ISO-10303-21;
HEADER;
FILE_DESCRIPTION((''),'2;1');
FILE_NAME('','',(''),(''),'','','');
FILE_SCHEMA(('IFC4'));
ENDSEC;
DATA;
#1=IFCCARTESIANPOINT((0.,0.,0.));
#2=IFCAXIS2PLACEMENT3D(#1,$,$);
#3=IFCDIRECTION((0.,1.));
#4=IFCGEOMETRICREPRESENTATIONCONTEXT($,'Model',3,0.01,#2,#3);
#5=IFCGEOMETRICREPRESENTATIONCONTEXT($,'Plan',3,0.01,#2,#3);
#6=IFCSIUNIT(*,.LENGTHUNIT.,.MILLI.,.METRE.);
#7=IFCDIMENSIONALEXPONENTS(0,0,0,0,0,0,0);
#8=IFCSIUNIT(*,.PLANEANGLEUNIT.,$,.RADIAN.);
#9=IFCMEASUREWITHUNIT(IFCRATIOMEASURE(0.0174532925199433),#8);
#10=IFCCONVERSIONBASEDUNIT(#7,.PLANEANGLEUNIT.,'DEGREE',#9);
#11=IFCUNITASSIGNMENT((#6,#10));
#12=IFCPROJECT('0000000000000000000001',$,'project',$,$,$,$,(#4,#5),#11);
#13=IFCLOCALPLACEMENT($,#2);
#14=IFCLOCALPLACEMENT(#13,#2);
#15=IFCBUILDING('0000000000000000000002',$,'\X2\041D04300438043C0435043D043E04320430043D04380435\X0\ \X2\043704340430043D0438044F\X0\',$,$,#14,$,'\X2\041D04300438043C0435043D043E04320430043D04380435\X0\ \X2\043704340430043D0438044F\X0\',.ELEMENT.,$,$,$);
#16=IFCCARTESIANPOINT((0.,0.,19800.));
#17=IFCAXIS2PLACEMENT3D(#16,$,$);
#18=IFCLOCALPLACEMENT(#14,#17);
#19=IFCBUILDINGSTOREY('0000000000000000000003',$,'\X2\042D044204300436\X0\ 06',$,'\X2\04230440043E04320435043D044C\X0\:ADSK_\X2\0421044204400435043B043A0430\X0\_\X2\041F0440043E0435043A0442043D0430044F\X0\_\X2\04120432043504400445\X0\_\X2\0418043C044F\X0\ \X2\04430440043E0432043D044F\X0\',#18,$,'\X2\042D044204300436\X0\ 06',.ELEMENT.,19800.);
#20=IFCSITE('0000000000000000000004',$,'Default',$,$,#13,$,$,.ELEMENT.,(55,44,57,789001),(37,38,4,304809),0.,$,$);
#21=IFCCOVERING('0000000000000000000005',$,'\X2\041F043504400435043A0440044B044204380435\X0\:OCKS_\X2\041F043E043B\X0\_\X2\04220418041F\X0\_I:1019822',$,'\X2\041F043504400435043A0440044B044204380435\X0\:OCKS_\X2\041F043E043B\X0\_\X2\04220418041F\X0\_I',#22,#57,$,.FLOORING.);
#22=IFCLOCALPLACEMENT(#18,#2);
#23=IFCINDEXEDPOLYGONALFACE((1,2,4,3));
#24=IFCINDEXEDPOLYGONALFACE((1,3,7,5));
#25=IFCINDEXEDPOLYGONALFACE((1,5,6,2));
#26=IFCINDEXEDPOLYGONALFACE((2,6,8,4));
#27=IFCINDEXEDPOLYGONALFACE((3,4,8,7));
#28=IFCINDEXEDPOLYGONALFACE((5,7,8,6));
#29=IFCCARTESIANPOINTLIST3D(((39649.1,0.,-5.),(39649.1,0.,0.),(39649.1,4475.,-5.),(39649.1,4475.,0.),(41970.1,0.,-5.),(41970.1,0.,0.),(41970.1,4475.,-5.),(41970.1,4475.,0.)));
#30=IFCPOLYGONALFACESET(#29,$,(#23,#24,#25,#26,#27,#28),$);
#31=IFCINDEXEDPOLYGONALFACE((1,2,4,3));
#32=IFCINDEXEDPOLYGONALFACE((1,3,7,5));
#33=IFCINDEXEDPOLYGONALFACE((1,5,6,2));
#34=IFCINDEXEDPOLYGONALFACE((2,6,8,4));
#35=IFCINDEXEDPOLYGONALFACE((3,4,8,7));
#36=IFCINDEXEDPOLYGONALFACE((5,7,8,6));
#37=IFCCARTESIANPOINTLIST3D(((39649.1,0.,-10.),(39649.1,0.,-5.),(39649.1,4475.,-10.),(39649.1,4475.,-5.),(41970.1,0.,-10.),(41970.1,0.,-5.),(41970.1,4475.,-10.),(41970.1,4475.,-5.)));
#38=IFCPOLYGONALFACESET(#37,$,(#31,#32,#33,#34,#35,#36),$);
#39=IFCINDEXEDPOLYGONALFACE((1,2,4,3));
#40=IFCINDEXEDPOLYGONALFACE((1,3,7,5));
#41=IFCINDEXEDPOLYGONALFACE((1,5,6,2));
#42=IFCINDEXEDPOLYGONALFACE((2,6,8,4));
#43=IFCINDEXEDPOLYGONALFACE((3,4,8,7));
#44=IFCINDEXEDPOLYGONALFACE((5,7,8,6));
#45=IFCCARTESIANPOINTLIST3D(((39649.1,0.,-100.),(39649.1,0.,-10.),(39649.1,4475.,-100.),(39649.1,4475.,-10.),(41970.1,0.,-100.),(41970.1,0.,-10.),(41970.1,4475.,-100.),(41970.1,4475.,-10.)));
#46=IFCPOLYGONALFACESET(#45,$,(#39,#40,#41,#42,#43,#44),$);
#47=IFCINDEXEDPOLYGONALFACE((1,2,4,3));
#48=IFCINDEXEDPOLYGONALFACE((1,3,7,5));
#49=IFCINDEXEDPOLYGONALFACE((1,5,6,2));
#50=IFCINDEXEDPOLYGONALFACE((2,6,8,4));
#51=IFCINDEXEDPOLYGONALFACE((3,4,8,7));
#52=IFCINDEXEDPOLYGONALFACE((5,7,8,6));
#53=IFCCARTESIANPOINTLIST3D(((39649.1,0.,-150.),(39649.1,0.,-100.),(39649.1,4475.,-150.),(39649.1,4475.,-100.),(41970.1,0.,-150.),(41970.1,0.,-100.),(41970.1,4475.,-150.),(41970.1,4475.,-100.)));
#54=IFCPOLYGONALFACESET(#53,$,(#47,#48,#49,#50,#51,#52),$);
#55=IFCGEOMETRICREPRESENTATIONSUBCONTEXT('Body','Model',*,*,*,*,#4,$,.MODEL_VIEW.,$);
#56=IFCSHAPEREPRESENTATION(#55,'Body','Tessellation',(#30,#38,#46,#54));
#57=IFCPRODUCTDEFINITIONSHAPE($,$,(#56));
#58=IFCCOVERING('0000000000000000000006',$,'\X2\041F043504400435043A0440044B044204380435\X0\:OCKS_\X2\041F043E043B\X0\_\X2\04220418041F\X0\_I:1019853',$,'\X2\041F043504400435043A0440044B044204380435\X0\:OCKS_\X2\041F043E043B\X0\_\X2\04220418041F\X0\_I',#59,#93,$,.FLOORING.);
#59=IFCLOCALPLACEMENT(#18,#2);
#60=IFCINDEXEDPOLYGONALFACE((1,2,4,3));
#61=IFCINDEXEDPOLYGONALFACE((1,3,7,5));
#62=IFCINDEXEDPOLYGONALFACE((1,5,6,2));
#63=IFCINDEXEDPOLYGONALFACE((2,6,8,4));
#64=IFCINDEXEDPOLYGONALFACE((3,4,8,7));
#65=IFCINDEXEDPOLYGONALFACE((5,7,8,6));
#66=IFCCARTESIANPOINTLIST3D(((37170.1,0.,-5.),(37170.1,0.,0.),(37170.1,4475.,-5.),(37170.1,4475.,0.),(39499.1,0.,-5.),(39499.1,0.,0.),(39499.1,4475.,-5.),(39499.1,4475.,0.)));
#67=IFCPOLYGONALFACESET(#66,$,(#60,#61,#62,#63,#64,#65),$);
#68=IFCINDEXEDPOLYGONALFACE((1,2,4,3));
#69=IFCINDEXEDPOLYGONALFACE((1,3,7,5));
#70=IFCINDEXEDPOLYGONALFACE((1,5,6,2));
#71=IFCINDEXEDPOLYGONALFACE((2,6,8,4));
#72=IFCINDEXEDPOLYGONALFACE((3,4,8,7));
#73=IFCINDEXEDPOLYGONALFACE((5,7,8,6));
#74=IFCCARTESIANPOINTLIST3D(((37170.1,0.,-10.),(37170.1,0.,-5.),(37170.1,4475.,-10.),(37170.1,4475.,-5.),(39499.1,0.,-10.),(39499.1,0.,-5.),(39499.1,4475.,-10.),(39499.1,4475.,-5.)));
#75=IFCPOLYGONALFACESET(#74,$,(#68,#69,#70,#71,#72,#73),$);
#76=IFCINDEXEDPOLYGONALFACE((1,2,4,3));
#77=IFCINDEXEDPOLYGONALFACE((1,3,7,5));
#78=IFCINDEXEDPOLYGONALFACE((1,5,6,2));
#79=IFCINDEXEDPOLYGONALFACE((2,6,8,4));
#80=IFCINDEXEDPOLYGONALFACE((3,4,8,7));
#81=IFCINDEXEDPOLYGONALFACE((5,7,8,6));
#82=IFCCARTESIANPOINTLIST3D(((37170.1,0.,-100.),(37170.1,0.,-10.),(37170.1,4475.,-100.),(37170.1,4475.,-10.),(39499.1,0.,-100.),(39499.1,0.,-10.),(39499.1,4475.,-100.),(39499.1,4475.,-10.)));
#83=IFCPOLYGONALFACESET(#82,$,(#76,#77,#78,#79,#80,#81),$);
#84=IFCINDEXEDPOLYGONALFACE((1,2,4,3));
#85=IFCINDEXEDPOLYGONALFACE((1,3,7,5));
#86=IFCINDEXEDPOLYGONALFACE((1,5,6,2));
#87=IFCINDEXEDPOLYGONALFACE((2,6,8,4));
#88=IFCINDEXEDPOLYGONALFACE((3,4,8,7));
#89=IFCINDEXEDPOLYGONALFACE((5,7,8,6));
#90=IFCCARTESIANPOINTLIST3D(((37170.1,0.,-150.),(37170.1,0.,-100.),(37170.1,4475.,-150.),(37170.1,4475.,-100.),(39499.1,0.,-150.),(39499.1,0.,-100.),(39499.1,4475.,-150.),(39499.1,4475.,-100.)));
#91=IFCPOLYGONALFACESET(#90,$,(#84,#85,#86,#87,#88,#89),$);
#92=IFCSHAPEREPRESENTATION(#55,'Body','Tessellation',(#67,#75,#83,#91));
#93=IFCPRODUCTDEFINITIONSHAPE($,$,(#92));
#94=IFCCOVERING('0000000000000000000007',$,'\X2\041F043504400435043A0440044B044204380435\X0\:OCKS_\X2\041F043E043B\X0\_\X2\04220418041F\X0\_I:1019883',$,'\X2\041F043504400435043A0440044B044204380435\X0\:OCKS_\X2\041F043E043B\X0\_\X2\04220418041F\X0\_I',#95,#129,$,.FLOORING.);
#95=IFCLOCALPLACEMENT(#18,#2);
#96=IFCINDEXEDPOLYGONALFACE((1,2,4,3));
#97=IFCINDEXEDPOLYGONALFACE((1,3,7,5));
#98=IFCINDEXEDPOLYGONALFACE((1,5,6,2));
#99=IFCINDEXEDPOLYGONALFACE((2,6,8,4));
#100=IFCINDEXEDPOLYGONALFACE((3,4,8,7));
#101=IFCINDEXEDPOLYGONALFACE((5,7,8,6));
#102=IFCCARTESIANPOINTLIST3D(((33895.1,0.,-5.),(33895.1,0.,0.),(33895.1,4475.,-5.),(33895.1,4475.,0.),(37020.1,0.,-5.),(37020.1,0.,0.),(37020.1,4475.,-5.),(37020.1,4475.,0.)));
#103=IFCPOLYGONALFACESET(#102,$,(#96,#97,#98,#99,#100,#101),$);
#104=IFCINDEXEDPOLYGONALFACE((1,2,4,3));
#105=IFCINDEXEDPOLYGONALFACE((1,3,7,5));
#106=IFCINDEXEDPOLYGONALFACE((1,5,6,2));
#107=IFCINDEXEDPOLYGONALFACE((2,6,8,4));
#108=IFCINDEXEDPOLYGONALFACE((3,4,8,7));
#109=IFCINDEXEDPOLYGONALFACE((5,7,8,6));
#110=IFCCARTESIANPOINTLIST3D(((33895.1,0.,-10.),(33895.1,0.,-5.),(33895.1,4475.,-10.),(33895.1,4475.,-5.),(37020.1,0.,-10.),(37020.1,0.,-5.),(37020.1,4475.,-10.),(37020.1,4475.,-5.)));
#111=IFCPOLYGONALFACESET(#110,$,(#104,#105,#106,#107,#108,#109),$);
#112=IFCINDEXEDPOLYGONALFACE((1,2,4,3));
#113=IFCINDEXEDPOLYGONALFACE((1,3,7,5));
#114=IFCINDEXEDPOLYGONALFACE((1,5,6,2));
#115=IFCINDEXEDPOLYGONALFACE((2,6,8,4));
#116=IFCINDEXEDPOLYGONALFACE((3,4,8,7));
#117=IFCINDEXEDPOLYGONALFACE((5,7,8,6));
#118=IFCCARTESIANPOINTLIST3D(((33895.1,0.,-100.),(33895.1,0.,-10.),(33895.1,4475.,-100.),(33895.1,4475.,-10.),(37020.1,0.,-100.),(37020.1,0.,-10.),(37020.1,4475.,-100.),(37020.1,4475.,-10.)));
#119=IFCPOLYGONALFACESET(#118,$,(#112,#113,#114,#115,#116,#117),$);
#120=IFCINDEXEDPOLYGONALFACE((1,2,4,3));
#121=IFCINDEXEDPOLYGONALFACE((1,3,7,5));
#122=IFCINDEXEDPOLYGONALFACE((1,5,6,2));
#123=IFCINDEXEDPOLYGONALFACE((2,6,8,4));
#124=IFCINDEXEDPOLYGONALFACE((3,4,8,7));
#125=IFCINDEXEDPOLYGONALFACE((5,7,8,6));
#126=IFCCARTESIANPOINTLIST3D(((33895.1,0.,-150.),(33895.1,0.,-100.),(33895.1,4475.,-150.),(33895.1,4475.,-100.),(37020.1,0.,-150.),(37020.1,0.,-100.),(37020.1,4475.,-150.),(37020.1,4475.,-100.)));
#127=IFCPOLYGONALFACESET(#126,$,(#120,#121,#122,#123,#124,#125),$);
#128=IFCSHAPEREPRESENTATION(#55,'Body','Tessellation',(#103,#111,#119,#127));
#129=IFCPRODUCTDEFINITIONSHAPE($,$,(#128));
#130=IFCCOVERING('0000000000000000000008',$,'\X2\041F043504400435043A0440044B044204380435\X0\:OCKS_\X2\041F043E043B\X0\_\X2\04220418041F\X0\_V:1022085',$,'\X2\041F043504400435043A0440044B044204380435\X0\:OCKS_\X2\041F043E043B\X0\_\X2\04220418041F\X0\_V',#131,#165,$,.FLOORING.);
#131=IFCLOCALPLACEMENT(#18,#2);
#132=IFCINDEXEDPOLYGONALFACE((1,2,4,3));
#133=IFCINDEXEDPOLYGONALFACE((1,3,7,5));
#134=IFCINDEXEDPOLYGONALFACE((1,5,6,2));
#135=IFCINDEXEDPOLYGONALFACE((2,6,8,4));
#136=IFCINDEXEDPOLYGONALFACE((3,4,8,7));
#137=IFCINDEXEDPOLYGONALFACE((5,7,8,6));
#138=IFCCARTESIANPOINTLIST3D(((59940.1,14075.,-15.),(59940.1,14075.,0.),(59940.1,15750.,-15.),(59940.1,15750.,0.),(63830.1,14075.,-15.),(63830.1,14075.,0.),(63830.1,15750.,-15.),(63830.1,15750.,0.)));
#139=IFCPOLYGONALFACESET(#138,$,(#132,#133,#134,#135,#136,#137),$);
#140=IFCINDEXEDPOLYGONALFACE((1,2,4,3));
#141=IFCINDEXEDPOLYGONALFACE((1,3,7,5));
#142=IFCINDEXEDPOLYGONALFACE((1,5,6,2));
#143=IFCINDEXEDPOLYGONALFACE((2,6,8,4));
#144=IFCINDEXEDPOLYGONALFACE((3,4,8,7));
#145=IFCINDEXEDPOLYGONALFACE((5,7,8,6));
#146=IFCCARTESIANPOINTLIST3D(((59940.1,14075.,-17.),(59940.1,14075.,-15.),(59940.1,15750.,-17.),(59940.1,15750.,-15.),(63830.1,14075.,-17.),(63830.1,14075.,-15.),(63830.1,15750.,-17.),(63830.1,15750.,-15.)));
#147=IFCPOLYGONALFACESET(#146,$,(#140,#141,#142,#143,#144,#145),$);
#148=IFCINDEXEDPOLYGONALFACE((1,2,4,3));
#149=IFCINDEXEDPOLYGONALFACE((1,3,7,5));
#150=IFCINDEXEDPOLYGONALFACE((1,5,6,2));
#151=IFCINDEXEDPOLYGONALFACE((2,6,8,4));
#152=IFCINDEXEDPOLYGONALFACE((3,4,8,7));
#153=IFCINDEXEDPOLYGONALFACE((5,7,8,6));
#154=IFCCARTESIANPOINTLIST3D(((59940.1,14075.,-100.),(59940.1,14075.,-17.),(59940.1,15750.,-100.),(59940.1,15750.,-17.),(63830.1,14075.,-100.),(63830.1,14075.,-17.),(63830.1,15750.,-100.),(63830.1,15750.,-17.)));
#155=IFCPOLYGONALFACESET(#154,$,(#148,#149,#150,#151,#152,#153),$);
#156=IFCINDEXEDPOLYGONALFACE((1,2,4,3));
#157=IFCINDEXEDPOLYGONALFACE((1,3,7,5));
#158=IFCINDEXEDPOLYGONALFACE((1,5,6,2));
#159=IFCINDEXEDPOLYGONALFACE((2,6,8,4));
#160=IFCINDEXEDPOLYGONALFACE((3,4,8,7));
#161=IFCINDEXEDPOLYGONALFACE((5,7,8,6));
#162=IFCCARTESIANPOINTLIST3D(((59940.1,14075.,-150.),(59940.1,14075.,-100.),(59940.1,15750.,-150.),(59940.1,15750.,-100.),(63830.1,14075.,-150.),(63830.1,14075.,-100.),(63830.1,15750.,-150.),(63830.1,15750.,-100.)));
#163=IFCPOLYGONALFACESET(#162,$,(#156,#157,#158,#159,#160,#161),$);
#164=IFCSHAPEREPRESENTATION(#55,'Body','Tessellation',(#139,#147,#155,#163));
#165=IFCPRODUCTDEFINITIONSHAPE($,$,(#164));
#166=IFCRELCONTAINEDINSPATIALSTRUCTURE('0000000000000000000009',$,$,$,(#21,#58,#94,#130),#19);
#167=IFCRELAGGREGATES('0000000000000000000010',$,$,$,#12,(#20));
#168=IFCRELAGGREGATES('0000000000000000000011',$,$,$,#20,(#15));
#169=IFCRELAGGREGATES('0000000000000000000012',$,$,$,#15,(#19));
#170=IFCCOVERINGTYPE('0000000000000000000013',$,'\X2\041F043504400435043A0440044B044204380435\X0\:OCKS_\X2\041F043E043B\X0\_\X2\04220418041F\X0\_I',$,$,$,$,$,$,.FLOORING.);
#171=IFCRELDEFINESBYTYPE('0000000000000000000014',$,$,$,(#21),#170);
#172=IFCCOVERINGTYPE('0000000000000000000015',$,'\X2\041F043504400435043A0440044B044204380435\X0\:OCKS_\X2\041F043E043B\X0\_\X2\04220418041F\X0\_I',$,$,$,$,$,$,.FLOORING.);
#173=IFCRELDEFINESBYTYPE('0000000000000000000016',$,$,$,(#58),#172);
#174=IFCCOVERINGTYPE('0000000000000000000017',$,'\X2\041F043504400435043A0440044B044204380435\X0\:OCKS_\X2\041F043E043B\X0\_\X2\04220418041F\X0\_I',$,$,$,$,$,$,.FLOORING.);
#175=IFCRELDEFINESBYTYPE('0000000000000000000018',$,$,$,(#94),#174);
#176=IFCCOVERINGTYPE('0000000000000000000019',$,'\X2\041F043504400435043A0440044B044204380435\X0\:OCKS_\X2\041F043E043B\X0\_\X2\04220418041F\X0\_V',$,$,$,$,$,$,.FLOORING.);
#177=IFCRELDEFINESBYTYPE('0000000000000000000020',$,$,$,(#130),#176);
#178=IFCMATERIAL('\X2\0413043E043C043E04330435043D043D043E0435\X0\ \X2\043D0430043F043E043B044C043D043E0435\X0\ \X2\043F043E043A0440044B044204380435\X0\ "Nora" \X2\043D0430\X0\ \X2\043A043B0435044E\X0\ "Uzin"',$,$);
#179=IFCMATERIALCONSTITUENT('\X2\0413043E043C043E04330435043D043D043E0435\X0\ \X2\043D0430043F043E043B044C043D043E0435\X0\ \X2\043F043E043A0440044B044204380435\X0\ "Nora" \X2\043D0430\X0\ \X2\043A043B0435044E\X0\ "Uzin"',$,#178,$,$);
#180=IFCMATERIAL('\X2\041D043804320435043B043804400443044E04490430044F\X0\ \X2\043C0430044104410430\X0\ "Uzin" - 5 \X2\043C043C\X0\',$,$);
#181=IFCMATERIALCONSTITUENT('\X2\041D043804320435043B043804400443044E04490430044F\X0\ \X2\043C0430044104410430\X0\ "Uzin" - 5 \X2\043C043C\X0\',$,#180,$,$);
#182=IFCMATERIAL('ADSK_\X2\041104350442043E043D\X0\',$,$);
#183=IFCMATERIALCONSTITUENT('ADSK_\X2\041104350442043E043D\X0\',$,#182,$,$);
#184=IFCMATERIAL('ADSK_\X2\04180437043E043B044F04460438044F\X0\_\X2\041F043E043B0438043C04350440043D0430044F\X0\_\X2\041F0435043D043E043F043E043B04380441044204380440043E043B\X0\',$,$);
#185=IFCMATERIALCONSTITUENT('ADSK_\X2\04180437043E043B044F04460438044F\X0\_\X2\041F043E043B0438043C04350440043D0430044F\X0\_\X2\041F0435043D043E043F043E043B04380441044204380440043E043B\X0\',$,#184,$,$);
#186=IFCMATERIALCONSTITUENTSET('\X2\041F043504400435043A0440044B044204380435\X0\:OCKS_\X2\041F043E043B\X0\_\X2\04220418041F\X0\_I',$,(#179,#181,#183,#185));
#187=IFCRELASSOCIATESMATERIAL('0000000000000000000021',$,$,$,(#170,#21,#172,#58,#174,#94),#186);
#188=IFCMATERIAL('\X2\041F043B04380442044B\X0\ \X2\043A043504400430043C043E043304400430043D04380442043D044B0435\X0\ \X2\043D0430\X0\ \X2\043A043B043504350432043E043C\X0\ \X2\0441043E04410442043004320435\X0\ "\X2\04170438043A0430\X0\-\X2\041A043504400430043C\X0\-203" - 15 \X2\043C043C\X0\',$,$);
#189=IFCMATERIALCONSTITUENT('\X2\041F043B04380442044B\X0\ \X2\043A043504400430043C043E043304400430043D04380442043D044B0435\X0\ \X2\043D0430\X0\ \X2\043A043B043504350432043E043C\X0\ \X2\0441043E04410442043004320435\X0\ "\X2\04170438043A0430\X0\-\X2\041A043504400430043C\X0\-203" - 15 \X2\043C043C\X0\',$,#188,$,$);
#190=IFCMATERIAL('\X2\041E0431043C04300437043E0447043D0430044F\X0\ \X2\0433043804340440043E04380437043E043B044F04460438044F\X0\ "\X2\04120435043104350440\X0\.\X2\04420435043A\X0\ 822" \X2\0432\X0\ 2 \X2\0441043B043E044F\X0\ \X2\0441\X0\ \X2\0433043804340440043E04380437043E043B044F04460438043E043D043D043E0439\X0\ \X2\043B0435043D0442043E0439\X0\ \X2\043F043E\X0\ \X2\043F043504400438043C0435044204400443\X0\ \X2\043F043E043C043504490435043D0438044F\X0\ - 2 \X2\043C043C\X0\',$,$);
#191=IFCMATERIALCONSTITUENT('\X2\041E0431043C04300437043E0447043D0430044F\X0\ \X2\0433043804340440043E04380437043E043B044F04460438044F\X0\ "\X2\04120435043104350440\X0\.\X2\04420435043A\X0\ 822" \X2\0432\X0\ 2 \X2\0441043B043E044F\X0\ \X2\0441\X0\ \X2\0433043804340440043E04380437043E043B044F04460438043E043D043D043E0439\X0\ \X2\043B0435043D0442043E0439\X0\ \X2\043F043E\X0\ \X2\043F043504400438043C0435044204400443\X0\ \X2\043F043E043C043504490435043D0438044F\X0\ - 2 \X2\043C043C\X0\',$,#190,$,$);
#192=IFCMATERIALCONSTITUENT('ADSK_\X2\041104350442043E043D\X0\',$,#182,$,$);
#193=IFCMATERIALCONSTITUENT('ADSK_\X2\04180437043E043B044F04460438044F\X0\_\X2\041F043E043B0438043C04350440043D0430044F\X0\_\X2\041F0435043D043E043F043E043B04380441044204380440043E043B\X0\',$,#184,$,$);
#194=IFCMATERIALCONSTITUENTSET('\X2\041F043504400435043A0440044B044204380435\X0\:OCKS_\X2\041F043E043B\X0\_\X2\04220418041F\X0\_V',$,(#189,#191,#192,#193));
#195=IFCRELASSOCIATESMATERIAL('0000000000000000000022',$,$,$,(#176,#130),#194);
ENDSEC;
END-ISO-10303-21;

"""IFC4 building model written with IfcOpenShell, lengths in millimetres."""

from ifc_helpers import new_model, entity, si_unit, converted_unit, direction, frame, origin, place, context, subcontext, project, spatial, indexed_curve, outline, extrude, material, constituent, constituent_set, type_object, element, save


model = new_model("IFC4")

# Units and contexts
model_context = context("Model", 3, precision=0.01, world=origin(), true_north=direction((0.0, 1.0)))
plan_context = context("Plan", 3, precision=0.01, world=origin(), true_north=direction((0.0, 1.0)))
body_context = subcontext(model_context, "Body", "Model", "MODEL_VIEW")
ifc_project = project(units=[si_unit("LENGTHUNIT", "METRE", prefix="MILLI"), converted_unit("PLANEANGLEUNIT", "DEGREE", entity("IfcRatioMeasure", 0.0174532925199433), si_unit("PLANEANGLEUNIT", "RADIAN"), dimensions=[0, 0, 0, 0, 0, 0, 0])], contexts=[model_context, plan_context])

# Site, building, storey
site_placement = place(None, frame((0.0, 0.0, 0.0)))
site = spatial("IfcSite", under=ifc_project, at=site_placement, Name="Default", CompositionType="ELEMENT", RefLatitude=(55, 44, 57, 789001), RefLongitude=(37, 38, 4, 304809), RefElevation=0.0)
building_placement = place(site_placement, origin())
building = spatial("IfcBuilding", under=site, at=building_placement, Name="Наименование здания", LongName="Наименование здания", CompositionType="ELEMENT")
storey_placement = place(building_placement, frame((0.0, 0.0, 19800.0)))
storey = spatial("IfcBuildingStorey", under=building, at=storey_placement, Name="Этаж 06", ObjectType="Уровень:ADSK_Стрелка_Проектная_Вверх_Имя уровня", LongName="Этаж 06", CompositionType="ELEMENT", Elevation=19800.0)

# Coverings
ifc_material_1 = material(Name="Плиты керамогранитные на клеевом составе \"Зика-Керам-203\" - 15 мм")
ifc_constituent_1 = constituent(ifc_material_1, Name="Плиты керамогранитные на клеевом составе \"Зика-Керам-203\" - 15 мм")
ifc_material_2 = material(Name="Обмазочная гидроизоляция \"Вебер.тек 822\" в 2 слоя с гидроизоляционной лентой по периметру помещения - 2 мм")
ifc_constituent_2 = constituent(ifc_material_2, Name="Обмазочная гидроизоляция \"Вебер.тек 822\" в 2 слоя с гидроизоляционной лентой по периметру помещения - 2 мм")
ifc_material_3 = material(Name="ADSK_Бетон")
ifc_constituent_3 = constituent(ifc_material_3, Name="ADSK_Бетон")
ifc_material_4 = material(Name="ADSK_Изоляция_Полимерная_Пенополистирол")
ifc_constituent_4 = constituent(ifc_material_4, Name="ADSK_Изоляция_Полимерная_Пенополистирол")
ifc_constituent_set_1 = constituent_set(constituents=[ifc_constituent_1, ifc_constituent_2, ifc_constituent_3, ifc_constituent_4], Name="Перекрытие:OCKS_Пол_ТИП_V")
ifc_material_5 = material(Name="Гомогенное напольное покрытие \"Nora\" на клею \"Uzin\"")
ifc_constituent_5 = constituent(ifc_material_5, Name="Гомогенное напольное покрытие \"Nora\" на клею \"Uzin\"")
ifc_material_6 = material(Name="Нивелирующая масса \"Uzin\" - 5 мм")
ifc_constituent_6 = constituent(ifc_material_6, Name="Нивелирующая масса \"Uzin\" - 5 мм")
ifc_constituent_7 = constituent(ifc_material_3, Name="ADSK_Бетон")
ifc_constituent_8 = constituent(ifc_material_4, Name="ADSK_Изоляция_Полимерная_Пенополистирол")
ifc_constituent_set_2 = constituent_set(constituents=[ifc_constituent_5, ifc_constituent_6, ifc_constituent_7, ifc_constituent_8], Name="Перекрытие:OCKS_Пол_ТИП_I")
covering_type_1 = type_object("IfcCoveringType", Name="Перекрытие:OCKS_Пол_ТИП_I", PredefinedType="FLOORING", material=ifc_constituent_set_2)
covering_1_placement = place(storey_placement, origin())
element("IfcCovering", 1, at=covering_1_placement, inside=storey, type_object=covering_type_1, material=ifc_constituent_set_2, Name="Перекрытие:OCKS_Пол_ТИП_I:1019822", ObjectType="Перекрытие:OCKS_Пол_ТИП_I", PredefinedType="FLOORING", context=body_context, shape_type="SweptSolid", body=[
    extrude(outline(indexed_curve([(-1160.5, -2237.5), (1160.5, -2237.5), (1160.5, 2237.5), (-1160.5, 2237.5), (-1160.5, -2237.5)], self_intersect=False)), frame((40809.6, 2237.5, -5.0), z_axis=(0.0, 0.0, 1.0), x_axis=(-1.0, 0.0, 0.0)), (0.0, 0.0, 1.0), 5.0),
    extrude(outline(indexed_curve([(-1160.5, -2237.5), (1160.5, -2237.5), (1160.5, 2237.5), (-1160.5, 2237.5), (-1160.5, -2237.5)], self_intersect=False)), frame((40809.6, 2237.5, -10.0), z_axis=(0.0, 0.0, 1.0), x_axis=(-1.0, 0.0, 0.0)), (0.0, 0.0, 1.0), 5.0),
    extrude(outline(indexed_curve([(-1160.5, -2237.5), (1160.5, -2237.5), (1160.5, 2237.5), (-1160.5, 2237.5), (-1160.5, -2237.5)], self_intersect=False)), frame((40809.6, 2237.5, -100.0), z_axis=(0.0, 0.0, 1.0), x_axis=(-1.0, 0.0, 0.0)), (0.0, 0.0, 1.0), 90.0),
    extrude(outline(indexed_curve([(-1160.5, -2237.5), (1160.5, -2237.5), (1160.5, 2237.5), (-1160.5, 2237.5), (-1160.5, -2237.5)], self_intersect=False)), frame((40809.6, 2237.5, -150.0), z_axis=(0.0, 0.0, 1.0), x_axis=(-1.0, 0.0, 0.0)), (0.0, 0.0, 1.0), 50.0),
])
covering_type_2 = type_object("IfcCoveringType", Name="Перекрытие:OCKS_Пол_ТИП_I", PredefinedType="FLOORING", material=ifc_constituent_set_2)
covering_2_placement = place(storey_placement, origin())
element("IfcCovering", 2, at=covering_2_placement, inside=storey, type_object=covering_type_2, material=ifc_constituent_set_2, Name="Перекрытие:OCKS_Пол_ТИП_I:1019853", ObjectType="Перекрытие:OCKS_Пол_ТИП_I", PredefinedType="FLOORING", context=body_context, shape_type="SweptSolid", body=[
    extrude(outline(indexed_curve([(-1164.5, -2237.5), (1164.5, -2237.5), (1164.5, 2237.5), (-1164.5, 2237.5), (-1164.5, -2237.5)], self_intersect=False)), frame((38334.6, 2237.5, -5.0), z_axis=(0.0, 0.0, 1.0), x_axis=(-1.0, 0.0, 0.0)), (0.0, 0.0, 1.0), 5.0),
    extrude(outline(indexed_curve([(-1164.5, -2237.5), (1164.5, -2237.5), (1164.5, 2237.5), (-1164.5, 2237.5), (-1164.5, -2237.5)], self_intersect=False)), frame((38334.6, 2237.5, -10.0), z_axis=(0.0, 0.0, 1.0), x_axis=(-1.0, 0.0, 0.0)), (0.0, 0.0, 1.0), 5.0),
    extrude(outline(indexed_curve([(-1164.5, -2237.5), (1164.5, -2237.5), (1164.5, 2237.5), (-1164.5, 2237.5), (-1164.5, -2237.5)], self_intersect=False)), frame((38334.6, 2237.5, -100.0), z_axis=(0.0, 0.0, 1.0), x_axis=(-1.0, 0.0, 0.0)), (0.0, 0.0, 1.0), 90.0),
    extrude(outline(indexed_curve([(-1164.5, -2237.5), (1164.5, -2237.5), (1164.5, 2237.5), (-1164.5, 2237.5), (-1164.5, -2237.5)], self_intersect=False)), frame((38334.6, 2237.5, -150.0), z_axis=(0.0, 0.0, 1.0), x_axis=(-1.0, 0.0, 0.0)), (0.0, 0.0, 1.0), 50.0),
])
covering_type_3 = type_object("IfcCoveringType", Name="Перекрытие:OCKS_Пол_ТИП_I", PredefinedType="FLOORING", material=ifc_constituent_set_2)
covering_3_placement = place(storey_placement, origin())
element("IfcCovering", 3, at=covering_3_placement, inside=storey, type_object=covering_type_3, material=ifc_constituent_set_2, Name="Перекрытие:OCKS_Пол_ТИП_I:1019883", ObjectType="Перекрытие:OCKS_Пол_ТИП_I", PredefinedType="FLOORING", context=body_context, shape_type="SweptSolid", body=[
    extrude(outline(indexed_curve([(-1562.5, -2237.5), (1562.5, -2237.5), (1562.5, 2237.5), (-1562.5, 2237.5), (-1562.5, -2237.5)], self_intersect=False)), frame((35457.6, 2237.5, -5.0), z_axis=(0.0, 0.0, 1.0), x_axis=(-1.0, 0.0, 0.0)), (0.0, 0.0, 1.0), 5.0),
    extrude(outline(indexed_curve([(-1562.5, -2237.5), (1562.5, -2237.5), (1562.5, 2237.5), (-1562.5, 2237.5), (-1562.5, -2237.5)], self_intersect=False)), frame((35457.6, 2237.5, -10.0), z_axis=(0.0, 0.0, 1.0), x_axis=(-1.0, 0.0, 0.0)), (0.0, 0.0, 1.0), 5.0),
    extrude(outline(indexed_curve([(-1562.5, -2237.5), (1562.5, -2237.5), (1562.5, 2237.5), (-1562.5, 2237.5), (-1562.5, -2237.5)], self_intersect=False)), frame((35457.6, 2237.5, -100.0), z_axis=(0.0, 0.0, 1.0), x_axis=(-1.0, 0.0, 0.0)), (0.0, 0.0, 1.0), 90.0),
    extrude(outline(indexed_curve([(-1562.5, -2237.5), (1562.5, -2237.5), (1562.5, 2237.5), (-1562.5, 2237.5), (-1562.5, -2237.5)], self_intersect=False)), frame((35457.6, 2237.5, -150.0), z_axis=(0.0, 0.0, 1.0), x_axis=(-1.0, 0.0, 0.0)), (0.0, 0.0, 1.0), 50.0),
])
covering_type_4 = type_object("IfcCoveringType", Name="Перекрытие:OCKS_Пол_ТИП_V", PredefinedType="FLOORING", material=ifc_constituent_set_1)
covering_4_placement = place(storey_placement, origin())
element("IfcCovering", 4, at=covering_4_placement, inside=storey, type_object=covering_type_4, material=ifc_constituent_set_1, Name="Перекрытие:OCKS_Пол_ТИП_V:1022085", ObjectType="Перекрытие:OCKS_Пол_ТИП_V", PredefinedType="FLOORING", context=body_context, shape_type="SweptSolid", body=[
    extrude(outline(indexed_curve([(-1945.0, -837.5), (1945.0, -837.5), (1945.0, 837.5), (-1945.0, 837.5), (-1945.0, -837.5)], self_intersect=False)), frame((61885.1, 14912.5, -15.0), z_axis=(0.0, 0.0, 1.0), x_axis=(-1.0, 0.0, 0.0)), (0.0, 0.0, 1.0), 15.0),
    extrude(outline(indexed_curve([(-1945.0, -837.5), (1945.0, -837.5), (1945.0, 837.5), (-1945.0, 837.5), (-1945.0, -837.5)], self_intersect=False)), frame((61885.1, 14912.5, -17.0), z_axis=(0.0, 0.0, 1.0), x_axis=(-1.0, 0.0, 0.0)), (0.0, 0.0, 1.0), 2.0),
    extrude(outline(indexed_curve([(-1945.0, -837.5), (1945.0, -837.5), (1945.0, 837.5), (-1945.0, 837.5), (-1945.0, -837.5)], self_intersect=False)), frame((61885.1, 14912.5, -100.0), z_axis=(0.0, 0.0, 1.0), x_axis=(-1.0, 0.0, 0.0)), (0.0, 0.0, 1.0), 83.0),
    extrude(outline(indexed_curve([(-1945.0, -837.5), (1945.0, -837.5), (1945.0, 837.5), (-1945.0, 837.5), (-1945.0, -837.5)], self_intersect=False)), frame((61885.1, 14912.5, -150.0), z_axis=(0.0, 0.0, 1.0), x_axis=(-1.0, 0.0, 0.0)), (0.0, 0.0, 1.0), 50.0),
])

save(model, "model.ifc")
